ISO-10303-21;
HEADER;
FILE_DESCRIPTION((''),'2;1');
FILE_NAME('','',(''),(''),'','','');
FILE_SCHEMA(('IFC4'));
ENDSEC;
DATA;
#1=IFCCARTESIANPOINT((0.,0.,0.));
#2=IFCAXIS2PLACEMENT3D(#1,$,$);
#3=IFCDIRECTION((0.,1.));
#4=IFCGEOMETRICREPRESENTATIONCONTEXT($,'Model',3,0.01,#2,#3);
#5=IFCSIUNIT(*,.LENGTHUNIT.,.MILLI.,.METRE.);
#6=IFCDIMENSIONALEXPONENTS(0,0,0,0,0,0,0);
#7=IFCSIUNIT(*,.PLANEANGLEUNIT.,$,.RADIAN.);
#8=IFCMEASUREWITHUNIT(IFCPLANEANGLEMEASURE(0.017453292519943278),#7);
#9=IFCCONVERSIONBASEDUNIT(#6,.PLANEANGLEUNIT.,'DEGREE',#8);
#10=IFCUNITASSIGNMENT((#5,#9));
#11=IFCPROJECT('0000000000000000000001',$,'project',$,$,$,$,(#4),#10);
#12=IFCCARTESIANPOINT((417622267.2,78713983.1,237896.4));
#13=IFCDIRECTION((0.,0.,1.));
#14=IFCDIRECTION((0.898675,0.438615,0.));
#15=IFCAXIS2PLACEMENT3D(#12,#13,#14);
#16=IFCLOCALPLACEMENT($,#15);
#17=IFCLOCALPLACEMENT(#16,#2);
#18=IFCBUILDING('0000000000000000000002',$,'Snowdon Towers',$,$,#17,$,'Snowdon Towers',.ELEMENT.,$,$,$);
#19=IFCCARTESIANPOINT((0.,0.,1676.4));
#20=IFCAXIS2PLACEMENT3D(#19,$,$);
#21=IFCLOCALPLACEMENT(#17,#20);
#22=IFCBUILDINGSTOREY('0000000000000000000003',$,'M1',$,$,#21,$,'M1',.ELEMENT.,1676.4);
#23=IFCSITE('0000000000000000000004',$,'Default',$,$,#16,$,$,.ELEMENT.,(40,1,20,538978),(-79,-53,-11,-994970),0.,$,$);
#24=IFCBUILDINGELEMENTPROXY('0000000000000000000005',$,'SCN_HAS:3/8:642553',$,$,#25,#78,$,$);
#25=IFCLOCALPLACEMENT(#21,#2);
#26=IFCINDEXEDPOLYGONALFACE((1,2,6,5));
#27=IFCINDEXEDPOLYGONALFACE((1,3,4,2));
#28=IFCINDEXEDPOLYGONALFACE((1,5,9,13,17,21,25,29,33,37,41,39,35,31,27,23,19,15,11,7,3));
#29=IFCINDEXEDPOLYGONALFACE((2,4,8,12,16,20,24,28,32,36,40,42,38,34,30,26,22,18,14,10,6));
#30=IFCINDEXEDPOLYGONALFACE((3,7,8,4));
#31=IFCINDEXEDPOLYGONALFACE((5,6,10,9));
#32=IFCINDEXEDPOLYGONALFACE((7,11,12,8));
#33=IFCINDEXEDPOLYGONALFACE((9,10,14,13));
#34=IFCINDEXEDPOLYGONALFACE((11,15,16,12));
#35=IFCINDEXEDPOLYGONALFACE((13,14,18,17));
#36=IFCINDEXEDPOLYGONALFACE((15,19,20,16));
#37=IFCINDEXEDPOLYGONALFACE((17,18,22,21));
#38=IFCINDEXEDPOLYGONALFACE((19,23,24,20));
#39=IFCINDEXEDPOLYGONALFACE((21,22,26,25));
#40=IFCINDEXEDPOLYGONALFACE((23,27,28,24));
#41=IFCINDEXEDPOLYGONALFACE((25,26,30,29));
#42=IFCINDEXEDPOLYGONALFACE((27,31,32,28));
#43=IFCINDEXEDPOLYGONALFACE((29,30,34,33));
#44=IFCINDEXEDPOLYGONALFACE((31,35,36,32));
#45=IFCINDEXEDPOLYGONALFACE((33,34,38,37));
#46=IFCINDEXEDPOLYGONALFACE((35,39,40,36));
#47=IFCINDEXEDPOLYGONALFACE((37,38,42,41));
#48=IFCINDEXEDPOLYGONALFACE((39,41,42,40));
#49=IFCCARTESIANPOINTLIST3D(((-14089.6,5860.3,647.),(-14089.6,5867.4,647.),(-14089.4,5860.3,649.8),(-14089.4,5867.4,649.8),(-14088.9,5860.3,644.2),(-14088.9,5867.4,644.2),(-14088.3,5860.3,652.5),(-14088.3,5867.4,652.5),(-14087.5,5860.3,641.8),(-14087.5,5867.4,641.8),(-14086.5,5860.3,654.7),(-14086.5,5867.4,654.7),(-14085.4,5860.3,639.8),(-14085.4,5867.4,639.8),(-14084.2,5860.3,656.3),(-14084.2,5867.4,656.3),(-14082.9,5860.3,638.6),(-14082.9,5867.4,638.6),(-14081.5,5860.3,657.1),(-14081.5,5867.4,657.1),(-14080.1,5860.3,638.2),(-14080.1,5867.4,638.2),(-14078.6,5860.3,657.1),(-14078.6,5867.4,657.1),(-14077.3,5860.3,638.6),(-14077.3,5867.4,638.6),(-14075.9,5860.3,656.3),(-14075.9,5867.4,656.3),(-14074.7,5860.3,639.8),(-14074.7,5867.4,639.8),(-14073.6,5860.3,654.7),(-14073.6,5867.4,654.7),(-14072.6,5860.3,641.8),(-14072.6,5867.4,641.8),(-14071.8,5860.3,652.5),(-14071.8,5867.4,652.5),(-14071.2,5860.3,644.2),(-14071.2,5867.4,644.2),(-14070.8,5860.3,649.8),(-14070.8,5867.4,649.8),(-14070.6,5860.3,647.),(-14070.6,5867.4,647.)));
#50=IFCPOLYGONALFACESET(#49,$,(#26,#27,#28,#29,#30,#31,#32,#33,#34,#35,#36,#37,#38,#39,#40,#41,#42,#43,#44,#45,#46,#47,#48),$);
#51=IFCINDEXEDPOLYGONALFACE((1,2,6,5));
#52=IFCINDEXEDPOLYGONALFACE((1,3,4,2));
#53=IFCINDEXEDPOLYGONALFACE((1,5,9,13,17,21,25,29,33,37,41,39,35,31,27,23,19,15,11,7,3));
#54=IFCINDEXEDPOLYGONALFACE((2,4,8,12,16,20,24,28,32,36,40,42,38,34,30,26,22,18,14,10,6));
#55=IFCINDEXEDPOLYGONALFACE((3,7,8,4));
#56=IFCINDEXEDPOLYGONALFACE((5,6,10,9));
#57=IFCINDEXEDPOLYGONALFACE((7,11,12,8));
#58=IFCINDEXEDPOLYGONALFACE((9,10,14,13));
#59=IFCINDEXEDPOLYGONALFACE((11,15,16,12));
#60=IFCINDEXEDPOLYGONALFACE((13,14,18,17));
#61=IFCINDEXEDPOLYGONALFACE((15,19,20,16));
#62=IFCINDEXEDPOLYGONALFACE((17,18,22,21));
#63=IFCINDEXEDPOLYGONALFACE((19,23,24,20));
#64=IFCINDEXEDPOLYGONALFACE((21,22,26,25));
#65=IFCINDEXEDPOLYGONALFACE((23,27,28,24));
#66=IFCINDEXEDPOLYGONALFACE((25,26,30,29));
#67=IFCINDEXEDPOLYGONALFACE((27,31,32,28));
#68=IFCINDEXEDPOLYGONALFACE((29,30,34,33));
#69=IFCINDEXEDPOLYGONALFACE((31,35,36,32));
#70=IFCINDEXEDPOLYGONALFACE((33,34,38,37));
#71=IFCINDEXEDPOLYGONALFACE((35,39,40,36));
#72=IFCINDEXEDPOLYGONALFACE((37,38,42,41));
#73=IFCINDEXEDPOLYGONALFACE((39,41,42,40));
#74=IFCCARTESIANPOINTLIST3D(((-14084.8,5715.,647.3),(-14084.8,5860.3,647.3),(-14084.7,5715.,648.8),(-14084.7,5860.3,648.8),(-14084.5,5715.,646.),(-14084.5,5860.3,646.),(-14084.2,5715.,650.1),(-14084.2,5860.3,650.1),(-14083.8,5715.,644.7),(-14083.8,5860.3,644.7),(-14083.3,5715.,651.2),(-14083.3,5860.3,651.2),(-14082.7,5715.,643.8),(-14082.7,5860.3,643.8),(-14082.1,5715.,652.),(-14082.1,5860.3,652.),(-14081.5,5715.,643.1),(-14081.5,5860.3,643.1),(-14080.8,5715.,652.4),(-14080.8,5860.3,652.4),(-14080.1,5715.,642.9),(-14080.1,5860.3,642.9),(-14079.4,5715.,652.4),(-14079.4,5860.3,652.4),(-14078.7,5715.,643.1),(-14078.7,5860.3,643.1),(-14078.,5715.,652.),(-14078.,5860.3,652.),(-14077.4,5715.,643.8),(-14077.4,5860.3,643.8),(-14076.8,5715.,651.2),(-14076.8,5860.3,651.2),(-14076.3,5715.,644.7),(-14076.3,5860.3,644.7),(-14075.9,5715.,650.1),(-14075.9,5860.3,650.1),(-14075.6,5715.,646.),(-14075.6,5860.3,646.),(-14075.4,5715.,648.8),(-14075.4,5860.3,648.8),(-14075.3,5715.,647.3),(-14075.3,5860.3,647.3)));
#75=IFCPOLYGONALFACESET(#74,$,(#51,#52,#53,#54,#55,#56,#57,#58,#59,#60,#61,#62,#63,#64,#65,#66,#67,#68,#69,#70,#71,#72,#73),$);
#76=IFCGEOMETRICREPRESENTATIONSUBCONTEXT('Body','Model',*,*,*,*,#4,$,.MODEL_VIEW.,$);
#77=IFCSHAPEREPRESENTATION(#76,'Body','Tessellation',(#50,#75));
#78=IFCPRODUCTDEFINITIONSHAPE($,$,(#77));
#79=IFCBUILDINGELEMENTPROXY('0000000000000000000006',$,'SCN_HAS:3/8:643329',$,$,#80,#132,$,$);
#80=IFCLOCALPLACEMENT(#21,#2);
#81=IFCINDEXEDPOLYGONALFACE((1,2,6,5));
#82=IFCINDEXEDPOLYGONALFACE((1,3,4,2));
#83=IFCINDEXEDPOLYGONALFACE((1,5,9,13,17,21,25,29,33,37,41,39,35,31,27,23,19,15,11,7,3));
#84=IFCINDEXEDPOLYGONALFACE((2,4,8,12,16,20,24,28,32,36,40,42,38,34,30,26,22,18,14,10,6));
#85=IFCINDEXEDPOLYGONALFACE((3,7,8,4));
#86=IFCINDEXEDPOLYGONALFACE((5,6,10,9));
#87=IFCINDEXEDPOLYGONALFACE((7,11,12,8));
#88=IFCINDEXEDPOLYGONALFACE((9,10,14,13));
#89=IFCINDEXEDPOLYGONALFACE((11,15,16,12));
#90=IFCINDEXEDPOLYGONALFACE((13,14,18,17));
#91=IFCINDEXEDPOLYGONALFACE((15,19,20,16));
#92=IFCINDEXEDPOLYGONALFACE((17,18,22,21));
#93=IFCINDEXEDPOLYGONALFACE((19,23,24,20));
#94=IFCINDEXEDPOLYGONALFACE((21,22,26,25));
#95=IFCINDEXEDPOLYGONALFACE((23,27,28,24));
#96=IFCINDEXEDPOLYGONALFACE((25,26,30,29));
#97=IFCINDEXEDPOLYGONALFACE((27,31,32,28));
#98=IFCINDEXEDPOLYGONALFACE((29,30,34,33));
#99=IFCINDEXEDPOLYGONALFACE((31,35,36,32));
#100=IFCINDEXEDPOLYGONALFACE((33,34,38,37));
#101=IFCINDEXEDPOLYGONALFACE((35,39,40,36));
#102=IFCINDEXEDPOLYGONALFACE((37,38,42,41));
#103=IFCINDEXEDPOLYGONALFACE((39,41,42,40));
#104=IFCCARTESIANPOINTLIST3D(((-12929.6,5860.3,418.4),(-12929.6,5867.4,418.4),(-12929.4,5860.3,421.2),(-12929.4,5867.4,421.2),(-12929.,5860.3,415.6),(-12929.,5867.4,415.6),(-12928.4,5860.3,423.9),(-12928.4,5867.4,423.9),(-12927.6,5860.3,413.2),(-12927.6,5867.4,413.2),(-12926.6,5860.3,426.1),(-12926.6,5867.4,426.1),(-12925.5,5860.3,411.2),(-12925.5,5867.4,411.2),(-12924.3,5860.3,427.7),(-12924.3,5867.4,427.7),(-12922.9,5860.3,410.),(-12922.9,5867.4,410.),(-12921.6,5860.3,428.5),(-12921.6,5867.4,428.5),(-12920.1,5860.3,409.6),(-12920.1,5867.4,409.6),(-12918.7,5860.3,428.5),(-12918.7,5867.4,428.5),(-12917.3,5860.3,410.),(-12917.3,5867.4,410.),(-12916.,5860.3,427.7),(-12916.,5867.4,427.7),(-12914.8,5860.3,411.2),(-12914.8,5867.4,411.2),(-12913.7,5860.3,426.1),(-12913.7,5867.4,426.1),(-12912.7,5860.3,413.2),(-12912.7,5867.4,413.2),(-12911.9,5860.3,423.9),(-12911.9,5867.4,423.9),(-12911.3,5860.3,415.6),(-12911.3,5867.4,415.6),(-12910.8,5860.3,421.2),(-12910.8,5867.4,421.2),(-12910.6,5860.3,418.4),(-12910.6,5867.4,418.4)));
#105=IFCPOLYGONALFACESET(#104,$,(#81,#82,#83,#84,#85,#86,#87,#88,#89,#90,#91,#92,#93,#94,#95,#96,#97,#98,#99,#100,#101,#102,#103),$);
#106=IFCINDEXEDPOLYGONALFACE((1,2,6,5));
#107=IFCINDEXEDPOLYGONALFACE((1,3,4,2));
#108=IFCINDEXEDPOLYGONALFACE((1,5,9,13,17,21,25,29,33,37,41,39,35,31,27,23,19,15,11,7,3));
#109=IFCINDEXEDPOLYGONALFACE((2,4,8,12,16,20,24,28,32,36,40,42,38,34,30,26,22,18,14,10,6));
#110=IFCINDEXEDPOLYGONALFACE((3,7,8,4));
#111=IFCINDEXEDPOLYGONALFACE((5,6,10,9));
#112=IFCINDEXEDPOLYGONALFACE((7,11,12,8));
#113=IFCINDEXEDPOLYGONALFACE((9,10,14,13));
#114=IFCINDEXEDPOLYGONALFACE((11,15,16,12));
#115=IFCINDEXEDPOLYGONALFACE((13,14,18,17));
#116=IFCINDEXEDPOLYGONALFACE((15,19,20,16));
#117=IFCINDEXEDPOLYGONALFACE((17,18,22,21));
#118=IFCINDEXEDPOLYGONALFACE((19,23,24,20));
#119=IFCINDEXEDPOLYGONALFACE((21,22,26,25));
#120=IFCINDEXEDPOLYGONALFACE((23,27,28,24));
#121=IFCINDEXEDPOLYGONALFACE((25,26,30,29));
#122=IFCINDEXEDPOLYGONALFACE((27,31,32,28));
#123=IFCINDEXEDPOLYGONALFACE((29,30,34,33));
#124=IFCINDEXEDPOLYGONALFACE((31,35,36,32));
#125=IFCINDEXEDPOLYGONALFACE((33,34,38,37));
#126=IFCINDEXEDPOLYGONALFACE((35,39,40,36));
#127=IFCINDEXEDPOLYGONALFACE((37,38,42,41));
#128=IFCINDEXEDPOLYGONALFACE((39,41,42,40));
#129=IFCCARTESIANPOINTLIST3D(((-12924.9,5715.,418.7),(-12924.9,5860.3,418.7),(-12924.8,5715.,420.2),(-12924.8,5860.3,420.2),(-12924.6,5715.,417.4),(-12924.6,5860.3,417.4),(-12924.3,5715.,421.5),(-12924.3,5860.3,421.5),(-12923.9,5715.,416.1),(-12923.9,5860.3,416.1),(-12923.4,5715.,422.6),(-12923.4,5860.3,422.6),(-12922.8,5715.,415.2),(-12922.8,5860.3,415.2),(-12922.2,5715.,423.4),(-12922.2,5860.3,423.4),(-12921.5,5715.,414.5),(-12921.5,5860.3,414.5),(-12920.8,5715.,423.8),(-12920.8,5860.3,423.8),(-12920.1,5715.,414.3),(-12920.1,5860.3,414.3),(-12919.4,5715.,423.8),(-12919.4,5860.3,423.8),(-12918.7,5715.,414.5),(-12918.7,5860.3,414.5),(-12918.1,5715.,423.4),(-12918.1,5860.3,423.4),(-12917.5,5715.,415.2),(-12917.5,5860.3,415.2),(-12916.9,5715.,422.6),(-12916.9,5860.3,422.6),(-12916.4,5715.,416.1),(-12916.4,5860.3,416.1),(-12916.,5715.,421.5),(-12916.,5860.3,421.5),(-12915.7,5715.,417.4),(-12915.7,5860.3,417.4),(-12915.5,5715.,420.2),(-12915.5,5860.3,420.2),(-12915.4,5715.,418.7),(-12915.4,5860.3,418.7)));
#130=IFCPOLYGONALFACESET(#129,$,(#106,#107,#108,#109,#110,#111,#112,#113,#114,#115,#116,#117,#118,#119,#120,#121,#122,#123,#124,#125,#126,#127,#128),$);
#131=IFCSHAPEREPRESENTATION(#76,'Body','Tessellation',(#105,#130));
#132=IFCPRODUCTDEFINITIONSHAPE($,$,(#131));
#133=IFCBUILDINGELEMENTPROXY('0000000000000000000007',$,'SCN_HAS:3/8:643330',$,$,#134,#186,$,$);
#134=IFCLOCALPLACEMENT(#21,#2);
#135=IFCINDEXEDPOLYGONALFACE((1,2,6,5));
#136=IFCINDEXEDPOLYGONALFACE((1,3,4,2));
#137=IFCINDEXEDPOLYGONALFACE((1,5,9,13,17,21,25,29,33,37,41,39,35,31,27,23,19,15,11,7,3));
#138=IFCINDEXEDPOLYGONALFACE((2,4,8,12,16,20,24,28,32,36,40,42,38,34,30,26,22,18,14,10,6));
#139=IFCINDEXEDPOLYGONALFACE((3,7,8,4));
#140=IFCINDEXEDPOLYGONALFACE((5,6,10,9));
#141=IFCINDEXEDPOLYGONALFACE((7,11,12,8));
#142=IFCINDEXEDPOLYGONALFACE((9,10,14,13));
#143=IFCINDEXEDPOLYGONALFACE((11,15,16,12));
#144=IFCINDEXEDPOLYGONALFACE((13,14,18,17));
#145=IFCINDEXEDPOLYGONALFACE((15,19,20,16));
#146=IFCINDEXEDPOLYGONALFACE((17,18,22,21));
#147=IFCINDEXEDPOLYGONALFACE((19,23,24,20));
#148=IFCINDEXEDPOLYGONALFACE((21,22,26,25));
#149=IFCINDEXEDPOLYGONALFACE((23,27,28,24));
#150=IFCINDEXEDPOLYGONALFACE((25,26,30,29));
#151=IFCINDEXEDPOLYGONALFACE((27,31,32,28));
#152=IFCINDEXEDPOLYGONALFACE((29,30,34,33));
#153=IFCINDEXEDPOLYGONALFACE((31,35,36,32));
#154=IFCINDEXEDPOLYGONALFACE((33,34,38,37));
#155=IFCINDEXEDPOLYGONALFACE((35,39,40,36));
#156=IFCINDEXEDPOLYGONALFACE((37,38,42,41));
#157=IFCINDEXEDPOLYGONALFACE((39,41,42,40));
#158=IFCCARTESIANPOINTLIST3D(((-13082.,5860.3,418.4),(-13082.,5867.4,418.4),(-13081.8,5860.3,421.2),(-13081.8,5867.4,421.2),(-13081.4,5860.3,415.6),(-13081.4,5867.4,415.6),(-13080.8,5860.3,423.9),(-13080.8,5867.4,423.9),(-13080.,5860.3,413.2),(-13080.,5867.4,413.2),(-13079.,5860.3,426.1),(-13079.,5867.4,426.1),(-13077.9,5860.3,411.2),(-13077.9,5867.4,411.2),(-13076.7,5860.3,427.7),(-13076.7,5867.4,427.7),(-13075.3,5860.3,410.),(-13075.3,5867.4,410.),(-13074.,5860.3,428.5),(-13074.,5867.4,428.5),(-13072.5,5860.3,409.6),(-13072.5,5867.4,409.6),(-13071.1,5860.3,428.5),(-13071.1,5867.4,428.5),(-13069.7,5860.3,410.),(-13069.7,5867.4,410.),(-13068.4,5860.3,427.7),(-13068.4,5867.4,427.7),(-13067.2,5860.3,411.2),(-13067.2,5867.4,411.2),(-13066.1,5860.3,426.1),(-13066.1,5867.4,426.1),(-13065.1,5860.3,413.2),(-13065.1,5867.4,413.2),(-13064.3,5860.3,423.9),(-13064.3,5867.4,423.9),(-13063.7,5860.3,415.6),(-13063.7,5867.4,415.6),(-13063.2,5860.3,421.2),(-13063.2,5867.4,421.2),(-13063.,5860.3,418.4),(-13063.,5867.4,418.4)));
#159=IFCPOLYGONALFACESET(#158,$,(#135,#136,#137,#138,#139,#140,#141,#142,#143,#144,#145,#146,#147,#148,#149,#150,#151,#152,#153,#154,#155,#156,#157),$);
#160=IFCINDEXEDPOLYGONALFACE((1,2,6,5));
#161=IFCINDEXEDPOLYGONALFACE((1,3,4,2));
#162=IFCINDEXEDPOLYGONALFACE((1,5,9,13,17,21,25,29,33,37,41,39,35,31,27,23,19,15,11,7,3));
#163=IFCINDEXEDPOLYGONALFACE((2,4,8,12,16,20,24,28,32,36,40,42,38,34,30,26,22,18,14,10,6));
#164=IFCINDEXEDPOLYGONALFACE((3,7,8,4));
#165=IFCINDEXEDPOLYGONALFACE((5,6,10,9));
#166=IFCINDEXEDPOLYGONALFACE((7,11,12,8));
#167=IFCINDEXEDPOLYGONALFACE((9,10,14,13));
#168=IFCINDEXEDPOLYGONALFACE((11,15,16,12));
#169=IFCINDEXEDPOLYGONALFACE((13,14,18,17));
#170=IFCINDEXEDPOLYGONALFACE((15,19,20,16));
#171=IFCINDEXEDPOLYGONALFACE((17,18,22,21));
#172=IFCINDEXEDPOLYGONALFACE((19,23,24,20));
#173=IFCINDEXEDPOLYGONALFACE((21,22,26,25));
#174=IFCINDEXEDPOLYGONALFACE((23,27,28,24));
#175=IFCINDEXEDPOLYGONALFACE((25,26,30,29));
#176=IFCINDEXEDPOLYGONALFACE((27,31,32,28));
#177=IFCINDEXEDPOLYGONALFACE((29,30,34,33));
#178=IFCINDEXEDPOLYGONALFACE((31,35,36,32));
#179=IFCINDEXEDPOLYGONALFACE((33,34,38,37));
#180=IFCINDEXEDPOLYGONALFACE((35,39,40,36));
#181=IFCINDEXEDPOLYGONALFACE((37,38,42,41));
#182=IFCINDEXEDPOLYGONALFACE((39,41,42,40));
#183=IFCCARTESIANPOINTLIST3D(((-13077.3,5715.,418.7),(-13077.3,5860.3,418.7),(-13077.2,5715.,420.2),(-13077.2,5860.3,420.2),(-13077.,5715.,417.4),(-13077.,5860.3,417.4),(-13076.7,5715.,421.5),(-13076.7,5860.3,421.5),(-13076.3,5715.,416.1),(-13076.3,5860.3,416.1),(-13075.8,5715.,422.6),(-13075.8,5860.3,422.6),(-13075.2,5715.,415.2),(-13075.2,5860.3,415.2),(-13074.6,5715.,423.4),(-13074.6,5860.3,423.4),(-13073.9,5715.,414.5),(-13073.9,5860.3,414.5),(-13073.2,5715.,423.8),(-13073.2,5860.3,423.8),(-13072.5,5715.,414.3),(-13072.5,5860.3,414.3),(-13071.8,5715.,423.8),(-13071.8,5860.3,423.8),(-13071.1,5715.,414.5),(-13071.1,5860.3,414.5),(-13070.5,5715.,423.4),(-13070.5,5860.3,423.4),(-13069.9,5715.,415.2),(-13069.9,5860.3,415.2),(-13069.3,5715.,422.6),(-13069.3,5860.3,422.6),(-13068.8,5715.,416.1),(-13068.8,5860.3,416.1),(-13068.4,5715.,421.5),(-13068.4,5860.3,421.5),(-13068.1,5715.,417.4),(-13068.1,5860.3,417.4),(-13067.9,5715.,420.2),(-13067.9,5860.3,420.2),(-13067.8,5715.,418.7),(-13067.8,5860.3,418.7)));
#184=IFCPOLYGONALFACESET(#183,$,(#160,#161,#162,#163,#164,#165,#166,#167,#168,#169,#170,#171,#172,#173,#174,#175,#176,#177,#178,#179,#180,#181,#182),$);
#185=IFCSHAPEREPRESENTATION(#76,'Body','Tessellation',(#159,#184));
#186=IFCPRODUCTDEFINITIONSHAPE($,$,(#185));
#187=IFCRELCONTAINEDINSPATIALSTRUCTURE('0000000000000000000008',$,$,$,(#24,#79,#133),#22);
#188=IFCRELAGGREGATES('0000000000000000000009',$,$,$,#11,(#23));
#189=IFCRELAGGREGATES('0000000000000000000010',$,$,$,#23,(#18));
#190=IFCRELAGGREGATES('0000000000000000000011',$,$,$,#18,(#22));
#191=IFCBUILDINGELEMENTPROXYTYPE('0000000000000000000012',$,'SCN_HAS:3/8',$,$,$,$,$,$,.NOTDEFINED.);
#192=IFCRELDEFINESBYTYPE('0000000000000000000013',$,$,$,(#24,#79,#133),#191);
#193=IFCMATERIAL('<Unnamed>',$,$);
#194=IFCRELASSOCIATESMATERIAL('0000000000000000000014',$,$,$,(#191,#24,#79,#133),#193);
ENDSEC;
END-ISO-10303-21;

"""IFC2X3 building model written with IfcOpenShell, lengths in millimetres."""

from ifc_helpers import new_model, entity, si_unit, converted_unit, direction, frame, frame_2d, origin, place, context, subcontext, project, spatial, circle, extrude, source, transform, mapped, material, type_object, type_shapes, element, save


model = new_model("IFC2X3")

# Units and contexts
model_context = context("Model", 3, precision=0.01, world=origin(), true_north=direction((0.0, 1.0)))
body_context = subcontext(model_context, "Body", "Model", "MODEL_VIEW")
ifc_project = project(units=[si_unit("LENGTHUNIT", "METRE", prefix="MILLI"), converted_unit("PLANEANGLEUNIT", "DEGREE", entity("IfcPlaneAngleMeasure", 0.017453292519943278), si_unit("PLANEANGLEUNIT", "RADIAN"), dimensions=[0, 0, 0, 0, 0, 0, 0])], contexts=[model_context])

# Site, building, storey
site_placement = place(None, frame((417622267.2, 78713983.1, 237896.4), z_axis=(0.0, 0.0, 1.0), x_axis=(0.898675, 0.438615, 0.0)))
site = spatial("IfcSite", under=ifc_project, at=site_placement, Name="Default", CompositionType="ELEMENT", RefLatitude=(40, 1, 20, 538978), RefLongitude=(-79, -53, -11, -994970), RefElevation=0.0)
building_placement = place(site_placement, origin())
building = spatial("IfcBuilding", under=site, at=building_placement, Name="Snowdon Towers", LongName="Snowdon Towers", CompositionType="ELEMENT")
storey_placement = place(building_placement, frame((0.0, 0.0, 1676.4)))
storey = spatial("IfcBuildingStorey", under=building, at=storey_placement, Name="M1", LongName="M1", CompositionType="ELEMENT", Elevation=1676.4)

# Building element proxies
ifc_material_1 = material(Name="<Unnamed>")
building_element_proxy_type = type_object("IfcBuildingElementProxyType", Name="SCN_HAS:3/8", PredefinedType="NOTDEFINED", material=ifc_material_1)
shared_shape_1 = source(origin(), body_context, "Body", "SweptSolid", [
    extrude(circle(Radius=9.5, at=frame_2d((0.0, 0.0), x_axis=(1.0, 0.0))), frame((0.0, 0.0, -152.4), z_axis=(0.0, 0.0, 1.0), x_axis=(0.0, -1.0, 0.0)), (0.0, 0.0, 1.0), 7.1),
    extrude(circle(Radius=4.8, at=frame_2d((0.0, 0.0), x_axis=(1.0, 0.0))), frame((0.0, 0.0, -145.3), z_axis=(0.0, 0.0, 1.0), x_axis=(0.0, -1.0, 0.0)), (0.0, 0.0, 1.0), 145.3),
])
type_shapes(building_element_proxy_type, [shared_shape_1])
for number, where, z_axis, x_axis, name in (
    (1, (-14080.1, 5715.0, 647.7), (0.0, -1.0, 0.0), (1.0, 0.0, 0.0), "SCN_HAS:3/8:642553"),
    (2, (-12920.1, 5715.0, 419.1), (0.0, -1.0, 0.0), (1.0, 0.0, 0.0), "SCN_HAS:3/8:643329"),
    (3, (-13072.5, 5715.0, 419.1), (0.0, -1.0, 0.0), (1.0, 0.0, 0.0), "SCN_HAS:3/8:643330"),
):
    element("IfcBuildingElementProxy", number, at=place(storey_placement, frame(where, z_axis=z_axis, x_axis=x_axis)), inside=storey, type_object=building_element_proxy_type, material=ifc_material_1, Name=name, context=body_context, shape_type="MappedRepresentation", body=[
        mapped(shared_shape_1, transform((0.0, 0.0, 0.0), scale=1.0)),
    ])

save(model, "model.ifc")
